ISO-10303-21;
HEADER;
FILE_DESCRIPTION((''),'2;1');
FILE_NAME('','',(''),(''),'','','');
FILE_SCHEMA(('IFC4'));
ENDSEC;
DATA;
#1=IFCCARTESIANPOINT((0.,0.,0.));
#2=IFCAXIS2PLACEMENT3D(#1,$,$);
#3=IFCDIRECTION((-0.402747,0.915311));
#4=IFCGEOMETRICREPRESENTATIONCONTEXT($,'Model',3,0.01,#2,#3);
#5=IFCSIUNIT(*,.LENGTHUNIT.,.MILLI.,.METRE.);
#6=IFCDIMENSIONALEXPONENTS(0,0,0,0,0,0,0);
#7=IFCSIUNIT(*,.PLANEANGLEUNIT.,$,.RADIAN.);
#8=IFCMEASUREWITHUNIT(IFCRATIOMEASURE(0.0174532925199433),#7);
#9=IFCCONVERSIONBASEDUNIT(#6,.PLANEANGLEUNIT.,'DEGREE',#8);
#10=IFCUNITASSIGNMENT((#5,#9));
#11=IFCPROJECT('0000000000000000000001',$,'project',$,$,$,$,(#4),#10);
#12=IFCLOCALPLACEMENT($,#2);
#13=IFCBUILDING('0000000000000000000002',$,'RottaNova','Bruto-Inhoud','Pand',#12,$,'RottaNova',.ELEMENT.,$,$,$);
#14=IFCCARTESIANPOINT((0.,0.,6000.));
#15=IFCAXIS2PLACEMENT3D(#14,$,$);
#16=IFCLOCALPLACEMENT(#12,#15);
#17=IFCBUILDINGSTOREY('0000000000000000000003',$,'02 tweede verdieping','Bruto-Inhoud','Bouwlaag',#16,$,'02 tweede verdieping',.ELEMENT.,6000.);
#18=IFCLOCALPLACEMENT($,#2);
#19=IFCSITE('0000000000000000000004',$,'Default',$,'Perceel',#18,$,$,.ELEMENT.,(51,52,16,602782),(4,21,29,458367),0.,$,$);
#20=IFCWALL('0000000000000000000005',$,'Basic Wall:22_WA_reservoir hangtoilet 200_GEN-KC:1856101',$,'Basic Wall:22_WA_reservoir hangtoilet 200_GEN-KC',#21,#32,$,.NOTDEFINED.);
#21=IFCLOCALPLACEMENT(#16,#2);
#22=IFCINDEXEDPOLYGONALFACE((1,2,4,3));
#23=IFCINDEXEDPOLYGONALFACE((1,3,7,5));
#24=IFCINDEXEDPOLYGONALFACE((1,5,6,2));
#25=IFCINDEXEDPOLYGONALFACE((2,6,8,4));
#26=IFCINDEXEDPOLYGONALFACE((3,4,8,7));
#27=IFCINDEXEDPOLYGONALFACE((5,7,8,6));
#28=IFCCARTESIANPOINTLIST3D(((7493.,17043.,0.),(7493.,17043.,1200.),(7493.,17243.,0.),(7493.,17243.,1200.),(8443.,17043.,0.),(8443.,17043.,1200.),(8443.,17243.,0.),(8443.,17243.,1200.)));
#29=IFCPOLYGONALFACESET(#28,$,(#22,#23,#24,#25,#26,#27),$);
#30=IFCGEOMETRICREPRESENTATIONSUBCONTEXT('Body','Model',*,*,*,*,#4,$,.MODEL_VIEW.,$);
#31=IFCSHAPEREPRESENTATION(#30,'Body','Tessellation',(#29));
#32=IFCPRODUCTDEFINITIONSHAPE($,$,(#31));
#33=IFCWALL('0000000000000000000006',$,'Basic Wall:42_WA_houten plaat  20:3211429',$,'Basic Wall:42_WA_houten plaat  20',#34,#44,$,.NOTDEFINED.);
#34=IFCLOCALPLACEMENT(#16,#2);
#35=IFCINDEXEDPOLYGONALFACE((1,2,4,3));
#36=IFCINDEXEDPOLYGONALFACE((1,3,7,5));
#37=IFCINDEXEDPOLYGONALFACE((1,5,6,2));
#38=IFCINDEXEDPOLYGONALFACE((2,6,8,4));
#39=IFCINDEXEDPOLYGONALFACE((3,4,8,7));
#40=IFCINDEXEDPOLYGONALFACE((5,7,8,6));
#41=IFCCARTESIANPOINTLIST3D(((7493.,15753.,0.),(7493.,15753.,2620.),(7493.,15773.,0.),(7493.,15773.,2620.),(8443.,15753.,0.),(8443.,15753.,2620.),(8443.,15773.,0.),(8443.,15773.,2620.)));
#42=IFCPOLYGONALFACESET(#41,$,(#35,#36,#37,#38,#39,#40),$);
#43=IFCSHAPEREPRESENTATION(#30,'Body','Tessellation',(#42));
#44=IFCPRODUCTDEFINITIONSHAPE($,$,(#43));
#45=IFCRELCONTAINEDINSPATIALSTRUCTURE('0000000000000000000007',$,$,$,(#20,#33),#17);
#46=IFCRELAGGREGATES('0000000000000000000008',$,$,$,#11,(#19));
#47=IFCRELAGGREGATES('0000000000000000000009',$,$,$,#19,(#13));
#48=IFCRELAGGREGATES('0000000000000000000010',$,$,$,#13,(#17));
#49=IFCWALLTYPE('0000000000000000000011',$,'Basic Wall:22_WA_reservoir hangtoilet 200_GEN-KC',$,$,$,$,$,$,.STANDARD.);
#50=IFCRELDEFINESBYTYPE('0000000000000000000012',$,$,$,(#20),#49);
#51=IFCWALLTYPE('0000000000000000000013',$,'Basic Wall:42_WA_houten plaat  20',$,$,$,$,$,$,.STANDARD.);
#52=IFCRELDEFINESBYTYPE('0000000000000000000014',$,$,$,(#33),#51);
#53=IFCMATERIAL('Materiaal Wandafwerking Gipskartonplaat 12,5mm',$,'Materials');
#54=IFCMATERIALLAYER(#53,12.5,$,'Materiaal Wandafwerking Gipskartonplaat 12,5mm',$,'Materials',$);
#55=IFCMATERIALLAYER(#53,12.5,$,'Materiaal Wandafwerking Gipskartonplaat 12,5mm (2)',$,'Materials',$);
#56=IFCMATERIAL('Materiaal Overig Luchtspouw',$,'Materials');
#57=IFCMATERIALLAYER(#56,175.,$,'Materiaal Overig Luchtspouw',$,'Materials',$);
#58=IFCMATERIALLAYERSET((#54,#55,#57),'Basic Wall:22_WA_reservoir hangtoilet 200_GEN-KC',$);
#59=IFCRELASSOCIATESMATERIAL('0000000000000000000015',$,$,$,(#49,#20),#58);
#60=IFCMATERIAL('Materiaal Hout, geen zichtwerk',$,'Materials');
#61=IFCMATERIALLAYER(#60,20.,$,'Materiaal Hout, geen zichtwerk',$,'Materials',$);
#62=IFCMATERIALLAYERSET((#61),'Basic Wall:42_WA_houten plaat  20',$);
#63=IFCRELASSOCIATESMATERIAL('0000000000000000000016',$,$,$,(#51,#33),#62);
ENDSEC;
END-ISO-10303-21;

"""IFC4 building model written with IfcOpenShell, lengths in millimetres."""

from ifc_helpers import new_model, entity, si_unit, converted_unit, direction, frame, frame_2d, origin, place, context, subcontext, project, spatial, rectangle, extrude, material, layer, layer_set, type_object, element, save


model = new_model("IFC4")

# Units and contexts
model_context = context("Model", 3, precision=0.01, world=origin(), true_north=direction((-0.402747, 0.915311)))
body_context = subcontext(model_context, "Body", "Model", "MODEL_VIEW")
ifc_project = project(units=[si_unit("LENGTHUNIT", "METRE", prefix="MILLI"), converted_unit("PLANEANGLEUNIT", "DEGREE", entity("IfcRatioMeasure", 0.0174532925199433), si_unit("PLANEANGLEUNIT", "RADIAN"), dimensions=[0, 0, 0, 0, 0, 0, 0])], contexts=[model_context])

# Site, building, storey
site_placement = place(None, origin())
site = spatial("IfcSite", under=ifc_project, at=site_placement, Name="Default", ObjectType="Perceel", CompositionType="ELEMENT", RefLatitude=(51, 52, 16, 602782), RefLongitude=(4, 21, 29, 458367), RefElevation=0.0)
building_placement = place(None, origin())
building = spatial("IfcBuilding", under=site, at=building_placement, Name="RottaNova", Description="Bruto-Inhoud", ObjectType="Pand", LongName="RottaNova", CompositionType="ELEMENT")
storey_placement = place(building_placement, frame((0.0, 0.0, 6000.0)))
storey = spatial("IfcBuildingStorey", under=building, at=storey_placement, Name="02 tweede verdieping", Description="Bruto-Inhoud", ObjectType="Bouwlaag", LongName="02 tweede verdieping", CompositionType="ELEMENT", Elevation=6000.0)

# Walls
ifc_material_1 = material(Name="Materiaal Wandafwerking Gipskartonplaat 12,5mm", Category="Materials")
ifc_layer_1 = layer(ifc_material_1, 12.5, Name="Materiaal Wandafwerking Gipskartonplaat 12,5mm", Category="Materials")
ifc_layer_2 = layer(ifc_material_1, 12.5, Name="Materiaal Wandafwerking Gipskartonplaat 12,5mm (2)", Category="Materials")
ifc_material_2 = material(Name="Materiaal Overig Luchtspouw", Category="Materials")
ifc_layer_3 = layer(ifc_material_2, 175.0, Name="Materiaal Overig Luchtspouw", Category="Materials")
ifc_layer_set_1 = layer_set([ifc_layer_1, ifc_layer_2, ifc_layer_3], Name="Basic Wall:22_WA_reservoir hangtoilet 200_GEN-KC")
wall_type_1 = type_object("IfcWallType", Name="Basic Wall:22_WA_reservoir hangtoilet 200_GEN-KC", PredefinedType="STANDARD", material=ifc_layer_set_1)
wall_1_placement = place(storey_placement, frame((7493.0, 17143.0, 0.0)))
element("IfcWall", 1, at=wall_1_placement, inside=storey, type_object=wall_type_1, material=ifc_layer_set_1, Name="Basic Wall:22_WA_reservoir hangtoilet 200_GEN-KC:1856101", ObjectType="Basic Wall:22_WA_reservoir hangtoilet 200_GEN-KC", PredefinedType="NOTDEFINED", context=body_context, shape_type="SweptSolid", body=[
    extrude(rectangle(XDim=950.0, YDim=200.0, at=frame_2d((475.0, 0.0), x_axis=(-1.0, 0.0))), origin(), (0.0, 0.0, 1.0), 1200.0),
])
ifc_material_3 = material(Name="Materiaal Hout, geen zichtwerk", Category="Materials")
ifc_layer_4 = layer(ifc_material_3, 20.0, Name="Materiaal Hout, geen zichtwerk", Category="Materials")
ifc_layer_set_2 = layer_set([ifc_layer_4], Name="Basic Wall:42_WA_houten plaat  20")
wall_type_2 = type_object("IfcWallType", Name="Basic Wall:42_WA_houten plaat  20", PredefinedType="STANDARD", material=ifc_layer_set_2)
wall_2_placement = place(storey_placement, frame((7493.0, 15763.0, 0.0)))
element("IfcWall", 2, at=wall_2_placement, inside=storey, type_object=wall_type_2, material=ifc_layer_set_2, Name="Basic Wall:42_WA_houten plaat  20:3211429", ObjectType="Basic Wall:42_WA_houten plaat  20", PredefinedType="NOTDEFINED", context=body_context, shape_type="SweptSolid", body=[
    extrude(rectangle(XDim=950.0, YDim=20.0, at=frame_2d((475.0, 0.0), x_axis=(-1.0, 0.0))), origin(), (0.0, 0.0, 1.0), 2620.0),
])

save(model, "model.ifc")
